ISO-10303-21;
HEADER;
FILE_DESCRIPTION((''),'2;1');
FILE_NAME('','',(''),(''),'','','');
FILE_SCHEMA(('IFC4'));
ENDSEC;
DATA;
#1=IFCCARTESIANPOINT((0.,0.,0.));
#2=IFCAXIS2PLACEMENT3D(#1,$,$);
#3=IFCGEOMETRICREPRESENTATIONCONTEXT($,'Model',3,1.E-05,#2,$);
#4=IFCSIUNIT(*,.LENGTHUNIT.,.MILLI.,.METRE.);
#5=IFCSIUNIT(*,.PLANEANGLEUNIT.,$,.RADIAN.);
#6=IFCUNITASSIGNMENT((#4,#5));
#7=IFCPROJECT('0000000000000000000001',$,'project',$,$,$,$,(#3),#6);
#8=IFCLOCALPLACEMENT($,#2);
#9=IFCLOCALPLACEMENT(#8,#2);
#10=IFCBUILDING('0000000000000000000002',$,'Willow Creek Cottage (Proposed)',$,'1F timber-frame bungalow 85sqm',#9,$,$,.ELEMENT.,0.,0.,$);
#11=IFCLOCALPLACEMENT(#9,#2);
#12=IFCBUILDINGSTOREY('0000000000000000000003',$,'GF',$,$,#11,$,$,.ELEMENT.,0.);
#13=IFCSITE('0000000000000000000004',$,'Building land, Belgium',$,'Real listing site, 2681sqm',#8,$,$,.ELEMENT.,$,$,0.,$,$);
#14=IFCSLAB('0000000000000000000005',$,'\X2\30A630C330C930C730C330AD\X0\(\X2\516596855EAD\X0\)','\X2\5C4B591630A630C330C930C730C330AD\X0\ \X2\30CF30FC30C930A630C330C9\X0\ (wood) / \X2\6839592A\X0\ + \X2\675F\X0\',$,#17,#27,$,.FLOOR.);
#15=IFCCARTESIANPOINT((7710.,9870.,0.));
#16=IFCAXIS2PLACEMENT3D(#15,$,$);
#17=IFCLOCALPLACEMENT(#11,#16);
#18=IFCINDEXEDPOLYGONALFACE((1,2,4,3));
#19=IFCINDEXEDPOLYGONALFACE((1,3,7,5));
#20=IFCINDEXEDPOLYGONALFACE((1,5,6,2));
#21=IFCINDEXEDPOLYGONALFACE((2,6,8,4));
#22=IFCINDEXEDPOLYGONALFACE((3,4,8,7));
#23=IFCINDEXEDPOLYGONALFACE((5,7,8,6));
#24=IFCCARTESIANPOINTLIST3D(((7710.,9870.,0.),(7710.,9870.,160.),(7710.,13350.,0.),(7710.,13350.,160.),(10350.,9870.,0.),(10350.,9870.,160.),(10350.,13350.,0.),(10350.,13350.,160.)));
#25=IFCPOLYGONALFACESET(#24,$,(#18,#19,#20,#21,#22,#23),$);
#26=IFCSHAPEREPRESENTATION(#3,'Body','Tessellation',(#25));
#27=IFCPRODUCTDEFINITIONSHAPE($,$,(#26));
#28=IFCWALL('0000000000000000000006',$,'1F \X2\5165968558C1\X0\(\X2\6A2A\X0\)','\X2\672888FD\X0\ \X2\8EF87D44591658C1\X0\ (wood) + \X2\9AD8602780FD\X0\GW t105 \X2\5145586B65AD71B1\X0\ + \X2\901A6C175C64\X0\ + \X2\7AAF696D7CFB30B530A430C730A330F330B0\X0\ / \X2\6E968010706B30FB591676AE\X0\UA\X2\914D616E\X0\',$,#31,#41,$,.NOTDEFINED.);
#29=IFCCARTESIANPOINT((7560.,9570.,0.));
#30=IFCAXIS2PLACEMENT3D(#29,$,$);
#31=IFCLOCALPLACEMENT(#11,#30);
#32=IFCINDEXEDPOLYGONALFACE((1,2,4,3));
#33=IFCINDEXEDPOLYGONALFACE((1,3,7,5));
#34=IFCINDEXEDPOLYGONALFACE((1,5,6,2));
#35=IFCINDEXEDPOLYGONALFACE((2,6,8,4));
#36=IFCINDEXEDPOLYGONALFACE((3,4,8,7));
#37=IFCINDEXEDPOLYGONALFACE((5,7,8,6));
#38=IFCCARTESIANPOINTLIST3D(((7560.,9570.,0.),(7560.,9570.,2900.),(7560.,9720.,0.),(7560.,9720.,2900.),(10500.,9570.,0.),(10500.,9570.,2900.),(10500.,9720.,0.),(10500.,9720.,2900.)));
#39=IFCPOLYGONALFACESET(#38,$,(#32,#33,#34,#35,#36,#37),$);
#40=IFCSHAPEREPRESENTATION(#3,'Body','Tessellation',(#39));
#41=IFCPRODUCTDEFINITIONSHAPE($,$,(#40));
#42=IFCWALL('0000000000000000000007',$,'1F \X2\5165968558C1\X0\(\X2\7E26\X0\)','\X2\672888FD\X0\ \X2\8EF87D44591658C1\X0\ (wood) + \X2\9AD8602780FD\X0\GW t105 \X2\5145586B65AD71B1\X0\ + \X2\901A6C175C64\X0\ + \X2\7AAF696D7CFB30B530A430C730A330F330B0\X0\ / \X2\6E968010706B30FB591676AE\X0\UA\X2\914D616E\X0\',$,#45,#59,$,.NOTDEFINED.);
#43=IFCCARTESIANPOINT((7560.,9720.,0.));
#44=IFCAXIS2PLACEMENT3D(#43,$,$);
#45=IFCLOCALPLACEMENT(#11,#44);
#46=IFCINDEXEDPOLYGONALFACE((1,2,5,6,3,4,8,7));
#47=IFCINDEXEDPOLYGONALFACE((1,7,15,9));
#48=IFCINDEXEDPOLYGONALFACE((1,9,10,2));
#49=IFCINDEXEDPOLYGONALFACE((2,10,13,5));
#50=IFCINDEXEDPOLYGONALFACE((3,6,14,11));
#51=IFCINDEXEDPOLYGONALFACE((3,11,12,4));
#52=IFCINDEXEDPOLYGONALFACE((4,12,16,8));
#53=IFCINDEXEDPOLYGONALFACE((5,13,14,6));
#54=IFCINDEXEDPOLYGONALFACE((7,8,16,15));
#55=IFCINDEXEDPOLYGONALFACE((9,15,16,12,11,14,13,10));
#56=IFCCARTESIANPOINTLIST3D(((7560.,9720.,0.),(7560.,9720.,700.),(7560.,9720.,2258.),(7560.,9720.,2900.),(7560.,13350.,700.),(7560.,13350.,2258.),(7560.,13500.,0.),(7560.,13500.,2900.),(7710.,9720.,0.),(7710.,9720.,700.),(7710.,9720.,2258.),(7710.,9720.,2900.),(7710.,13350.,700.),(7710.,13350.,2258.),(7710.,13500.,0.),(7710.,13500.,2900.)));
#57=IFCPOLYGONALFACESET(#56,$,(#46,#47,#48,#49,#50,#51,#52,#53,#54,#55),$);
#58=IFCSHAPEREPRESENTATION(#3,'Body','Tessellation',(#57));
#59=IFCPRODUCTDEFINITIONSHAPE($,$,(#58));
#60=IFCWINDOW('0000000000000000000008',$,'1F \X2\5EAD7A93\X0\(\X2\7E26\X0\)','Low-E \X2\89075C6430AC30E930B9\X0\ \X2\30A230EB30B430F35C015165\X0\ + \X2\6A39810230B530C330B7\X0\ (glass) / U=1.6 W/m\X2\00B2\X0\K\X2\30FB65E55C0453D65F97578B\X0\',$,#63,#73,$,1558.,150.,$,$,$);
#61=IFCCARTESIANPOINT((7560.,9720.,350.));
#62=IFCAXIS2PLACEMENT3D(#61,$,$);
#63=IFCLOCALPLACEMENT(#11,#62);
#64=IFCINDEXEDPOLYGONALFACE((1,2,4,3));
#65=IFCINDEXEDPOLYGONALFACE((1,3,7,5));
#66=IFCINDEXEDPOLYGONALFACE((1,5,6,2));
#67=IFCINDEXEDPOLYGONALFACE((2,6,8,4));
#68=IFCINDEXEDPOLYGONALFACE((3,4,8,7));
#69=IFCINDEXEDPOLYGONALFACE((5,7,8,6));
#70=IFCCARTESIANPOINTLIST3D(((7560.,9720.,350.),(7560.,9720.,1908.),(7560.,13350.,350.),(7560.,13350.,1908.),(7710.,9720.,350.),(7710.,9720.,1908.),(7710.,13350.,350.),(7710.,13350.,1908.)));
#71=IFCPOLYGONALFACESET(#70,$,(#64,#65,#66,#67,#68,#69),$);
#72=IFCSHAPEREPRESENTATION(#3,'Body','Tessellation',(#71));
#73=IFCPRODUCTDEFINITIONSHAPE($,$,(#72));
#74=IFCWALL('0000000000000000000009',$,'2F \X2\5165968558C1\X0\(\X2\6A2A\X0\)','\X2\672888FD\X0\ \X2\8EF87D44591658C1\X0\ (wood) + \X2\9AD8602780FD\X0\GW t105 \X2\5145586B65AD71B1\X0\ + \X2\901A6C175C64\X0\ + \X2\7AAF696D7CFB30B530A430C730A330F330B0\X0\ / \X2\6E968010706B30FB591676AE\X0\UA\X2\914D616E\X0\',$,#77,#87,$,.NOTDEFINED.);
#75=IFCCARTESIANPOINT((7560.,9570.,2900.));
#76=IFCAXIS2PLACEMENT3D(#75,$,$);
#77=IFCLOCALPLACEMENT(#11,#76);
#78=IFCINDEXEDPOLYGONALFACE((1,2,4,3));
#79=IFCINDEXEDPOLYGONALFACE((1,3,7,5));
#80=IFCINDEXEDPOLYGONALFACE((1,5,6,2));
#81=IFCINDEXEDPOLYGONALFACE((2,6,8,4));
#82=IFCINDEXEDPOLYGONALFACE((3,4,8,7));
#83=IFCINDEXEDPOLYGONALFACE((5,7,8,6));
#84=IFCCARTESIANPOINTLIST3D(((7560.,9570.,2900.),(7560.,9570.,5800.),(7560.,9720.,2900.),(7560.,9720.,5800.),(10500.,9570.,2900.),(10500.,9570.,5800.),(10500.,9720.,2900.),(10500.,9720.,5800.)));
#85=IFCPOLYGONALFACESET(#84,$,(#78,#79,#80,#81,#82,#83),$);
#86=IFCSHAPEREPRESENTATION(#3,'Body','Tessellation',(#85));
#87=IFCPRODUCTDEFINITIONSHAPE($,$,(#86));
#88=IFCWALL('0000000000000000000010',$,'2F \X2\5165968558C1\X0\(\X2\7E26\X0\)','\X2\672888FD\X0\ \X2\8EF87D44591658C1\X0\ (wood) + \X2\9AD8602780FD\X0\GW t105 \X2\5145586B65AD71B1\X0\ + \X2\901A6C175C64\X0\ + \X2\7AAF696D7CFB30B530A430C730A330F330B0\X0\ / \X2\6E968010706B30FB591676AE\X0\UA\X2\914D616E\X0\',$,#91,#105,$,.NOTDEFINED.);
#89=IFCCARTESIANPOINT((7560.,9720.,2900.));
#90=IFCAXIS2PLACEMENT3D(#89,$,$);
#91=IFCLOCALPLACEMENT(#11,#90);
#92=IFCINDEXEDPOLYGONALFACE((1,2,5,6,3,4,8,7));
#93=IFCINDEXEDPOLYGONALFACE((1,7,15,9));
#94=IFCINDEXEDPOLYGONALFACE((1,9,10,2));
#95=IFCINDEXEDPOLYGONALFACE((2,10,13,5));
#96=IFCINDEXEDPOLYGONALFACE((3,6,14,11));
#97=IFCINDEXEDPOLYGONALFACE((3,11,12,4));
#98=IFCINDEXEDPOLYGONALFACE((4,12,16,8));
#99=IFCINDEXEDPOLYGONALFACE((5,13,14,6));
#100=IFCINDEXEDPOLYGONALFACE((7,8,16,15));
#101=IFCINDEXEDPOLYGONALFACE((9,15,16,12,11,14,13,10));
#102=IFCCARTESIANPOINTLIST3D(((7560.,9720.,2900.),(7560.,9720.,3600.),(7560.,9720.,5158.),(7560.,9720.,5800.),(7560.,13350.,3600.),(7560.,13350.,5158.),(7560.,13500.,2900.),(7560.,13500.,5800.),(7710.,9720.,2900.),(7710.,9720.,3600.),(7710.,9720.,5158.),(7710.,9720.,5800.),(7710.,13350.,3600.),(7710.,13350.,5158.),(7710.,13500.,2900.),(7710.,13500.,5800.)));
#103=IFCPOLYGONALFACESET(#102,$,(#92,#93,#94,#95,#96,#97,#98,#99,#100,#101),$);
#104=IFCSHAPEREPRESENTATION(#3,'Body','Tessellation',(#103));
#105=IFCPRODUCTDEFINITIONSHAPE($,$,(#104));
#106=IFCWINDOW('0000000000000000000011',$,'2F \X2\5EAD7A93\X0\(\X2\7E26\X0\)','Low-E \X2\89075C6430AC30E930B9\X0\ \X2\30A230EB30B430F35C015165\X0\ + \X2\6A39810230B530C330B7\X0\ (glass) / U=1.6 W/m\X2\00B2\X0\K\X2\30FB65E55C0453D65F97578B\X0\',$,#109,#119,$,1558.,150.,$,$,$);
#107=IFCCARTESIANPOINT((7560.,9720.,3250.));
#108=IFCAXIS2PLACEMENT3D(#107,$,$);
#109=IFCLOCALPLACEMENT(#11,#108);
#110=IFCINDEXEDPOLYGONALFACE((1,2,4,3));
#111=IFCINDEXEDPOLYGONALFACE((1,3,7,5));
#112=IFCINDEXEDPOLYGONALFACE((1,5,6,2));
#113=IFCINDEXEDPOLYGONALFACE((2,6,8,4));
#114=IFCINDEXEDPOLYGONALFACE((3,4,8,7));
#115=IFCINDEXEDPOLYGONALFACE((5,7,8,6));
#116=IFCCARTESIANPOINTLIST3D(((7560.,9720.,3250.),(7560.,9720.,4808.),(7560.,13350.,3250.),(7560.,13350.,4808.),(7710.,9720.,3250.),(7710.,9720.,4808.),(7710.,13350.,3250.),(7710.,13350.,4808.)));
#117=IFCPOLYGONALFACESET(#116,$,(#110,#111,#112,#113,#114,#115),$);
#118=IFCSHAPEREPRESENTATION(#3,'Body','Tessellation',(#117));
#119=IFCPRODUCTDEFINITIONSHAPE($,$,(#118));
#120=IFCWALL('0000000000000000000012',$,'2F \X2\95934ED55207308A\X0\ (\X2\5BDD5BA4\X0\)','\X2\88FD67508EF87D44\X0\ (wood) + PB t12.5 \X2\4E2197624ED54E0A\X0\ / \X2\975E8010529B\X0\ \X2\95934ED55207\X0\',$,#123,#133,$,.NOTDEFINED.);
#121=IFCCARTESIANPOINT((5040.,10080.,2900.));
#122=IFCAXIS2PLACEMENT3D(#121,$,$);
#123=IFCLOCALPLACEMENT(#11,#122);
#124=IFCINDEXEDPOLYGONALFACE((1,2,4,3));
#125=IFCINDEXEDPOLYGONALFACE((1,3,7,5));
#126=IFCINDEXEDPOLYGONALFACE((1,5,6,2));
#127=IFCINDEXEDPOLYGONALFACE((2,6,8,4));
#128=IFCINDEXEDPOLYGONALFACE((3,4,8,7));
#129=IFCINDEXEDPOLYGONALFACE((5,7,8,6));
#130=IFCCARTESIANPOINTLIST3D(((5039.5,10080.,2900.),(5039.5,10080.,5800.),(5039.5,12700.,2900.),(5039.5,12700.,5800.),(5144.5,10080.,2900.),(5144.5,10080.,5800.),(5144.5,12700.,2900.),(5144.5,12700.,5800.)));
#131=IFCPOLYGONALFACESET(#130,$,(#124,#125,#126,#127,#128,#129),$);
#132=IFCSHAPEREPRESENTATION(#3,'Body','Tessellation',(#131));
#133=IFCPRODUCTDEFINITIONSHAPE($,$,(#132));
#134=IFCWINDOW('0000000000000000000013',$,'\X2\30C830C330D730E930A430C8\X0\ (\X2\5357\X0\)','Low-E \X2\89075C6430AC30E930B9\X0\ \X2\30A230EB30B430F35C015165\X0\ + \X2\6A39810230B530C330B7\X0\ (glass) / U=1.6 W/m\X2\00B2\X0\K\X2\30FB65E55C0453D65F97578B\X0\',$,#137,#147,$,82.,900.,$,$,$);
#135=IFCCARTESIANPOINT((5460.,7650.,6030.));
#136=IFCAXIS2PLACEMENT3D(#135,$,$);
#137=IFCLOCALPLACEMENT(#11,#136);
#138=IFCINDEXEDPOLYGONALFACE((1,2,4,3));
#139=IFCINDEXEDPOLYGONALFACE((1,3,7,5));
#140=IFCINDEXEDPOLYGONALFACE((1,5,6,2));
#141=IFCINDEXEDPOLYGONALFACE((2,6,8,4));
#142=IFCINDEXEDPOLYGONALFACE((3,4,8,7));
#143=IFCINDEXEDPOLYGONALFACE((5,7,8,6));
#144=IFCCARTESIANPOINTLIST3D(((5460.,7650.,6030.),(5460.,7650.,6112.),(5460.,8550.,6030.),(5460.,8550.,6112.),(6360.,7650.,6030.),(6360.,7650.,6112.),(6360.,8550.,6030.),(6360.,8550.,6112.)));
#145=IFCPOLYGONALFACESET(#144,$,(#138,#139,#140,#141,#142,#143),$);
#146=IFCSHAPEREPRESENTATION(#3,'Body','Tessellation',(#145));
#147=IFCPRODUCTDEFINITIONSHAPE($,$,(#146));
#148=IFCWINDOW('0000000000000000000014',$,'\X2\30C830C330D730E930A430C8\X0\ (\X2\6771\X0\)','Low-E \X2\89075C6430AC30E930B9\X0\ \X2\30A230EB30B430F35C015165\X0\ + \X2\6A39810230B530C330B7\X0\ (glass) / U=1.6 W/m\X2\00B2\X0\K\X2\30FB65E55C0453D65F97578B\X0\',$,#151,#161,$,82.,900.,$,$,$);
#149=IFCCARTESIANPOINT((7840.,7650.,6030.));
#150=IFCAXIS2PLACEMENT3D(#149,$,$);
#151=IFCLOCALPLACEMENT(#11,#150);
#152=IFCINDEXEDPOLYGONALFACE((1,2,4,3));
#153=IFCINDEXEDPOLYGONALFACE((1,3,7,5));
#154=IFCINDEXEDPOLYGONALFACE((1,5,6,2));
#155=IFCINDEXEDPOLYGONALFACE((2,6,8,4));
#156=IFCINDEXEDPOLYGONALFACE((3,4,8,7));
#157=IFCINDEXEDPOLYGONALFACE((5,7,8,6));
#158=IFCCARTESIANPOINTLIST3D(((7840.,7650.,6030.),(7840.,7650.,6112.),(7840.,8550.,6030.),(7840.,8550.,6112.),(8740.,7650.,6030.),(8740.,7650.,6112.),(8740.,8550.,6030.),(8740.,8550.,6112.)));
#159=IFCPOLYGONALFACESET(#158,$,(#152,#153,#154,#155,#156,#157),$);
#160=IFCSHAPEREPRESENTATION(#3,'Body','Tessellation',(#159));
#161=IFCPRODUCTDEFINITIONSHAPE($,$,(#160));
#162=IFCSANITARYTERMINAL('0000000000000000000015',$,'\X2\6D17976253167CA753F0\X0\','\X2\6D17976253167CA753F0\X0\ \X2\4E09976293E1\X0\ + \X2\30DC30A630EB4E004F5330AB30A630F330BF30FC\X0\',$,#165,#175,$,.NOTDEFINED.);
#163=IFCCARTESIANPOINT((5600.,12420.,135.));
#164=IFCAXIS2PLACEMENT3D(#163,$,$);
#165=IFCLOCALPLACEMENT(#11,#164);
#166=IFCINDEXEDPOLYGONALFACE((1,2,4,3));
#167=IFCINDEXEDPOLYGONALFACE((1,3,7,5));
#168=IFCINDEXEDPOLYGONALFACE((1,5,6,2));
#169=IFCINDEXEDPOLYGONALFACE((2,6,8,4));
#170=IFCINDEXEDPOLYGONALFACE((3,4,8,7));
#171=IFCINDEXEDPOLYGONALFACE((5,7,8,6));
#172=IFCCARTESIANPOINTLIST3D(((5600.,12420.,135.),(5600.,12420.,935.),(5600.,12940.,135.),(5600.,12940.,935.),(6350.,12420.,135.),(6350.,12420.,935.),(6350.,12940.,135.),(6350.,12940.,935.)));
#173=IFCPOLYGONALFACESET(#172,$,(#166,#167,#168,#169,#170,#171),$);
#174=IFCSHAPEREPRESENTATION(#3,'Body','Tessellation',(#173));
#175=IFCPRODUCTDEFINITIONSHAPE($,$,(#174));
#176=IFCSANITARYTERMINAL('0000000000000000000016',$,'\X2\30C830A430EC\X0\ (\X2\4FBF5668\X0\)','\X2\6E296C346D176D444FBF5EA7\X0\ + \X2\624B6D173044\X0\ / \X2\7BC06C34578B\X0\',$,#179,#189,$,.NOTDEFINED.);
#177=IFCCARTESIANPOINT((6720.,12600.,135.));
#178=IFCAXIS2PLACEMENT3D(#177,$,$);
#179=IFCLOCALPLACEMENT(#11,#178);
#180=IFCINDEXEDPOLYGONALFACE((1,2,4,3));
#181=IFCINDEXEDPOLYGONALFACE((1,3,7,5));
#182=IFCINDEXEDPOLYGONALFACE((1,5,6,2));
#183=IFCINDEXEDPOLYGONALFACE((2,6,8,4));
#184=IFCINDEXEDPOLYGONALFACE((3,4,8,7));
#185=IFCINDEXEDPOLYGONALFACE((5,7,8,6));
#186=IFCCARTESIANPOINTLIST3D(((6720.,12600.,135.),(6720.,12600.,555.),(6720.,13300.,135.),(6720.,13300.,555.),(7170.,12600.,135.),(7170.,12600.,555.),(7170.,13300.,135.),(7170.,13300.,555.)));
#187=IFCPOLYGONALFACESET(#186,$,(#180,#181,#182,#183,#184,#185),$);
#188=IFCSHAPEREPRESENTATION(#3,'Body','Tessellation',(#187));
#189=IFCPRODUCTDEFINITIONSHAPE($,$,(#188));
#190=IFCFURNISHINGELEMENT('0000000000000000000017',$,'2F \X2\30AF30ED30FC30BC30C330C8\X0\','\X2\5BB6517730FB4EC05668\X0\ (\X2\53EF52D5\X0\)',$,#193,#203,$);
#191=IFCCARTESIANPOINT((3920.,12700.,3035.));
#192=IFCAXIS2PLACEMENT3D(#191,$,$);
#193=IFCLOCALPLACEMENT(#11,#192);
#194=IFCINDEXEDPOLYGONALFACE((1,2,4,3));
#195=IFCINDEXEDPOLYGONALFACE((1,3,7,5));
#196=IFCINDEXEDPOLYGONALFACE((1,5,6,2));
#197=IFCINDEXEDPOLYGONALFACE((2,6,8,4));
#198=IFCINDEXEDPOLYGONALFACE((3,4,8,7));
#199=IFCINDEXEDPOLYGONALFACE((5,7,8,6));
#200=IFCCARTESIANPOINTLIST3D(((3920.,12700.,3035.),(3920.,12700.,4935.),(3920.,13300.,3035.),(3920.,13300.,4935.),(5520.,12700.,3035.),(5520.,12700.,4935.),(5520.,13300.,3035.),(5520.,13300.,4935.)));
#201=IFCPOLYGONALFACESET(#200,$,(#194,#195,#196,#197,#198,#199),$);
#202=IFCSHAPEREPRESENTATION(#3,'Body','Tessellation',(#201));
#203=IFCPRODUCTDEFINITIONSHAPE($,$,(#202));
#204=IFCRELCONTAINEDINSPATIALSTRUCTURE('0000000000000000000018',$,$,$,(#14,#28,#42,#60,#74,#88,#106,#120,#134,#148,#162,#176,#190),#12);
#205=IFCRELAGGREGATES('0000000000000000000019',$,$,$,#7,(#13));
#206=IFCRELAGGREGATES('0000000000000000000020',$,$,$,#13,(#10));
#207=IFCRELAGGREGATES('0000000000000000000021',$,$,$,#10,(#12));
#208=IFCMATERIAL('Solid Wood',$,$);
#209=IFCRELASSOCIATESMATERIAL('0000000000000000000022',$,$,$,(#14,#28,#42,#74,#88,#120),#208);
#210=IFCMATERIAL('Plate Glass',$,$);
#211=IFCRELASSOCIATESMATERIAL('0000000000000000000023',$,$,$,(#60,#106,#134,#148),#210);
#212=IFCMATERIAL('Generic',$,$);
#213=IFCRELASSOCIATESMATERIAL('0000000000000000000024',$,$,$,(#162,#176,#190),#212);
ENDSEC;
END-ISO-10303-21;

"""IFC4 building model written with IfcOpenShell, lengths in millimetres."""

from ifc_helpers import new_model, si_unit, frame, frame_2d, origin, place, context, project, spatial, rectangle, extrude, material, element, fill, save


model = new_model("IFC4")

# Units and contexts
model_context = context("Model", 3, precision=1e-05, world=origin())
ifc_project = project(units=[si_unit("LENGTHUNIT", "METRE", prefix="MILLI"), si_unit("PLANEANGLEUNIT", "RADIAN")], contexts=[model_context])

# Site, building, storey
site_placement = place(None, origin())
site = spatial("IfcSite", under=ifc_project, at=site_placement, Name="Building land, Belgium", ObjectType="Real listing site, 2681sqm", CompositionType="ELEMENT", RefElevation=0.0)
building_placement = place(site_placement, origin())
building = spatial("IfcBuilding", under=site, at=building_placement, Name="Willow Creek Cottage (Proposed)", ObjectType="1F timber-frame bungalow 85sqm", CompositionType="ELEMENT", ElevationOfRefHeight=0.0, ElevationOfTerrain=0.0)
storey_placement = place(building_placement, origin())
storey = spatial("IfcBuildingStorey", under=building, at=storey_placement, Name="GF", CompositionType="ELEMENT", Elevation=0.0)

# Slab
ifc_material_1 = material(Name="Solid Wood")
slab_placement = place(storey_placement, frame((7710.0, 9870.0, 0.0)))
element("IfcSlab", 1, at=slab_placement, inside=storey, material=ifc_material_1, Name="ウッドデッキ(入隅庭)", Description="屋外ウッドデッキ ハードウッド (wood) / 根太 + 束", PredefinedType="FLOOR", context=model_context, shape_type="SweptSolid", body=[
    extrude(rectangle(XDim=2640.0, YDim=3480.0, at=frame_2d((1320.0, 1740.0))), frame((7710.0, 9870.0, 0.0)), (0.0, 0.0, 1.0), 160.0),
])

# Wall
wall_1_placement = place(storey_placement, frame((7560.0, 9570.0, 0.0)))
element("IfcWall", 2, at=wall_1_placement, inside=storey, material=ifc_material_1, Name="1F 入隅壁(横)", Description="木製 軸組外壁 (wood) + 高性能GW t105 充填断熱 + 通気層 + 窯業系サイディング / 準耐火・外皮UA配慮", PredefinedType="NOTDEFINED", context=model_context, shape_type="SweptSolid", body=[
    extrude(rectangle(XDim=2940.0, YDim=150.0, at=frame_2d((1470.0, 75.0))), frame((7560.0, 9570.0, 0.0)), (0.0, 0.0, 1.0), 2900.0),
])

# Wall, opening, window
wall_2_placement = place(storey_placement, frame((7560.0, 9720.0, 0.0)))
wall_2 = element("IfcWall", 3, at=wall_2_placement, inside=storey, material=ifc_material_1, Name="1F 入隅壁(縦)", Description="木製 軸組外壁 (wood) + 高性能GW t105 充填断熱 + 通気層 + 窯業系サイディング / 準耐火・外皮UA配慮", PredefinedType="NOTDEFINED", context=model_context, shape_type="SweptSolid", body=[
    extrude(rectangle(XDim=150.0, YDim=3780.0, at=frame_2d((75.0, 1890.0))), frame((7560.0, 9720.0, 0.0)), (0.0, 0.0, 1.0), 2900.0),
])
opening_1_placement = place(storey_placement, frame((7560.0, 9720.0, 350.0)))
opening_1 = element("IfcOpeningElement", 4, at=opening_1_placement, cuts=wall_2, PredefinedType="NOTDEFINED", context=model_context, shape_type="SweptSolid", body=[
    extrude(rectangle(XDim=150.0, YDim=3630.0, at=frame_2d((75.0, 1815.0))), frame((7560.0, 9720.0, 350.0)), (0.0, 0.0, 1.0), 1558.0),
])
ifc_material_2 = material(Name="Plate Glass")
window_1_placement = place(storey_placement, frame((7560.0, 9720.0, 350.0)))
window_1 = element("IfcWindow", 5, at=window_1_placement, inside=storey, material=ifc_material_2, Name="1F 庭窓(縦)", Description="Low-E 複層ガラス アルゴン封入 + 樹脂サッシ (glass) / U=1.6 W/m²K・日射取得型", OverallHeight=1558.0, OverallWidth=150.0, context=model_context, shape_type="SweptSolid", body=[
    extrude(rectangle(XDim=150.0, YDim=3630.0, at=frame_2d((75.0, 1815.0))), frame((7560.0, 9720.0, 350.0)), (0.0, 0.0, 1.0), 1558.0),
])
fill(opening_1, window_1)

# Wall
wall_3_placement = place(storey_placement, frame((7560.0, 9570.0, 2900.0)))
element("IfcWall", 6, at=wall_3_placement, inside=storey, material=ifc_material_1, Name="2F 入隅壁(横)", Description="木製 軸組外壁 (wood) + 高性能GW t105 充填断熱 + 通気層 + 窯業系サイディング / 準耐火・外皮UA配慮", PredefinedType="NOTDEFINED", context=model_context, shape_type="SweptSolid", body=[
    extrude(rectangle(XDim=2940.0, YDim=150.0, at=frame_2d((1470.0, 75.0))), frame((7560.0, 9570.0, 2900.0)), (0.0, 0.0, 1.0), 2900.0),
])

# Wall, opening, window
wall_4_placement = place(storey_placement, frame((7560.0, 9720.0, 2900.0)))
wall_4 = element("IfcWall", 7, at=wall_4_placement, inside=storey, material=ifc_material_1, Name="2F 入隅壁(縦)", Description="木製 軸組外壁 (wood) + 高性能GW t105 充填断熱 + 通気層 + 窯業系サイディング / 準耐火・外皮UA配慮", PredefinedType="NOTDEFINED", context=model_context, shape_type="SweptSolid", body=[
    extrude(rectangle(XDim=150.0, YDim=3780.0, at=frame_2d((75.0, 1890.0))), frame((7560.0, 9720.0, 2900.0)), (0.0, 0.0, 1.0), 2900.0),
])
opening_2_placement = place(storey_placement, frame((7560.0, 9720.0, 3250.0)))
opening_2 = element("IfcOpeningElement", 8, at=opening_2_placement, cuts=wall_4, PredefinedType="NOTDEFINED", context=model_context, shape_type="SweptSolid", body=[
    extrude(rectangle(XDim=150.0, YDim=3630.0, at=frame_2d((75.0, 1815.0))), frame((7560.0, 9720.0, 3250.0)), (0.0, 0.0, 1.0), 1558.0),
])
window_2_placement = place(storey_placement, frame((7560.0, 9720.0, 3250.0)))
window_2 = element("IfcWindow", 9, at=window_2_placement, inside=storey, material=ifc_material_2, Name="2F 庭窓(縦)", Description="Low-E 複層ガラス アルゴン封入 + 樹脂サッシ (glass) / U=1.6 W/m²K・日射取得型", OverallHeight=1558.0, OverallWidth=150.0, context=model_context, shape_type="SweptSolid", body=[
    extrude(rectangle(XDim=150.0, YDim=3630.0, at=frame_2d((75.0, 1815.0))), frame((7560.0, 9720.0, 3250.0)), (0.0, 0.0, 1.0), 1558.0),
])
fill(opening_2, window_2)

# Wall
wall_5_placement = place(storey_placement, frame((5040.0, 10080.0, 2900.0)))
element("IfcWall", 10, at=wall_5_placement, inside=storey, material=ifc_material_1, Name="2F 間仕切り (寝室)", Description="製材軸組 (wood) + PB t12.5 両面仕上 / 非耐力 間仕切", PredefinedType="NOTDEFINED", context=model_context, shape_type="SweptSolid", body=[
    extrude(rectangle(XDim=105.0, YDim=2620.0, at=frame_2d((52.0, 1310.0))), frame((5040.0, 10080.0, 2900.0)), (0.0, 0.0, 1.0), 2900.0),
])

# Windows
window_3_placement = place(storey_placement, frame((5460.0, 7650.0, 6030.0)))
element("IfcWindow", 11, at=window_3_placement, inside=storey, material=ifc_material_2, Name="トップライト (南)", Description="Low-E 複層ガラス アルゴン封入 + 樹脂サッシ (glass) / U=1.6 W/m²K・日射取得型", OverallHeight=82.0, OverallWidth=900.0, context=model_context, shape_type="SweptSolid", body=[
    extrude(rectangle(XDim=900.0, YDim=900.0, at=frame_2d((450.0, 450.0))), frame((5460.0, 7650.0, 6030.0)), (0.0, 0.0, 1.0), 82.0),
])
window_4_placement = place(storey_placement, frame((7840.0, 7650.0, 6030.0)))
element("IfcWindow", 12, at=window_4_placement, inside=storey, material=ifc_material_2, Name="トップライト (東)", Description="Low-E 複層ガラス アルゴン封入 + 樹脂サッシ (glass) / U=1.6 W/m²K・日射取得型", OverallHeight=82.0, OverallWidth=900.0, context=model_context, shape_type="SweptSolid", body=[
    extrude(rectangle(XDim=900.0, YDim=900.0, at=frame_2d((450.0, 450.0))), frame((7840.0, 7650.0, 6030.0)), (0.0, 0.0, 1.0), 82.0),
])

# Sanitary terminals
ifc_material_3 = material(Name="Generic")
sanitary_terminal_1_placement = place(storey_placement, frame((5600.0, 12420.0, 135.0)))
element("IfcSanitaryTerminal", 13, at=sanitary_terminal_1_placement, inside=storey, material=ifc_material_3, Name="洗面化粧台", Description="洗面化粧台 三面鏡 + ボウル一体カウンター", PredefinedType="NOTDEFINED", context=model_context, shape_type="SweptSolid", body=[
    extrude(rectangle(XDim=750.0, YDim=520.0, at=frame_2d((375.0, 260.0))), frame((5600.0, 12420.0, 135.0)), (0.0, 0.0, 1.0), 800.0),
])
sanitary_terminal_2_placement = place(storey_placement, frame((6720.0, 12600.0, 135.0)))
element("IfcSanitaryTerminal", 14, at=sanitary_terminal_2_placement, inside=storey, material=ifc_material_3, Name="トイレ (便器)", Description="温水洗浄便座 + 手洗い / 節水型", PredefinedType="NOTDEFINED", context=model_context, shape_type="SweptSolid", body=[
    extrude(rectangle(XDim=450.0, YDim=700.0, at=frame_2d((225.0, 350.0))), frame((6720.0, 12600.0, 135.0)), (0.0, 0.0, 1.0), 420.0),
])

# Furnishing element
furnishing_1_placement = place(storey_placement, frame((3920.0, 12700.0, 3035.0)))
element("IfcFurnishingElement", 15, at=furnishing_1_placement, inside=storey, material=ifc_material_3, Name="2F クローゼット", Description="家具・什器 (可動)", context=model_context, shape_type="SweptSolid", body=[
    extrude(rectangle(XDim=1600.0, YDim=600.0, at=frame_2d((800.0, 300.0))), frame((3920.0, 12700.0, 3035.0)), (0.0, 0.0, 1.0), 1900.0),
])

save(model, "model.ifc")
